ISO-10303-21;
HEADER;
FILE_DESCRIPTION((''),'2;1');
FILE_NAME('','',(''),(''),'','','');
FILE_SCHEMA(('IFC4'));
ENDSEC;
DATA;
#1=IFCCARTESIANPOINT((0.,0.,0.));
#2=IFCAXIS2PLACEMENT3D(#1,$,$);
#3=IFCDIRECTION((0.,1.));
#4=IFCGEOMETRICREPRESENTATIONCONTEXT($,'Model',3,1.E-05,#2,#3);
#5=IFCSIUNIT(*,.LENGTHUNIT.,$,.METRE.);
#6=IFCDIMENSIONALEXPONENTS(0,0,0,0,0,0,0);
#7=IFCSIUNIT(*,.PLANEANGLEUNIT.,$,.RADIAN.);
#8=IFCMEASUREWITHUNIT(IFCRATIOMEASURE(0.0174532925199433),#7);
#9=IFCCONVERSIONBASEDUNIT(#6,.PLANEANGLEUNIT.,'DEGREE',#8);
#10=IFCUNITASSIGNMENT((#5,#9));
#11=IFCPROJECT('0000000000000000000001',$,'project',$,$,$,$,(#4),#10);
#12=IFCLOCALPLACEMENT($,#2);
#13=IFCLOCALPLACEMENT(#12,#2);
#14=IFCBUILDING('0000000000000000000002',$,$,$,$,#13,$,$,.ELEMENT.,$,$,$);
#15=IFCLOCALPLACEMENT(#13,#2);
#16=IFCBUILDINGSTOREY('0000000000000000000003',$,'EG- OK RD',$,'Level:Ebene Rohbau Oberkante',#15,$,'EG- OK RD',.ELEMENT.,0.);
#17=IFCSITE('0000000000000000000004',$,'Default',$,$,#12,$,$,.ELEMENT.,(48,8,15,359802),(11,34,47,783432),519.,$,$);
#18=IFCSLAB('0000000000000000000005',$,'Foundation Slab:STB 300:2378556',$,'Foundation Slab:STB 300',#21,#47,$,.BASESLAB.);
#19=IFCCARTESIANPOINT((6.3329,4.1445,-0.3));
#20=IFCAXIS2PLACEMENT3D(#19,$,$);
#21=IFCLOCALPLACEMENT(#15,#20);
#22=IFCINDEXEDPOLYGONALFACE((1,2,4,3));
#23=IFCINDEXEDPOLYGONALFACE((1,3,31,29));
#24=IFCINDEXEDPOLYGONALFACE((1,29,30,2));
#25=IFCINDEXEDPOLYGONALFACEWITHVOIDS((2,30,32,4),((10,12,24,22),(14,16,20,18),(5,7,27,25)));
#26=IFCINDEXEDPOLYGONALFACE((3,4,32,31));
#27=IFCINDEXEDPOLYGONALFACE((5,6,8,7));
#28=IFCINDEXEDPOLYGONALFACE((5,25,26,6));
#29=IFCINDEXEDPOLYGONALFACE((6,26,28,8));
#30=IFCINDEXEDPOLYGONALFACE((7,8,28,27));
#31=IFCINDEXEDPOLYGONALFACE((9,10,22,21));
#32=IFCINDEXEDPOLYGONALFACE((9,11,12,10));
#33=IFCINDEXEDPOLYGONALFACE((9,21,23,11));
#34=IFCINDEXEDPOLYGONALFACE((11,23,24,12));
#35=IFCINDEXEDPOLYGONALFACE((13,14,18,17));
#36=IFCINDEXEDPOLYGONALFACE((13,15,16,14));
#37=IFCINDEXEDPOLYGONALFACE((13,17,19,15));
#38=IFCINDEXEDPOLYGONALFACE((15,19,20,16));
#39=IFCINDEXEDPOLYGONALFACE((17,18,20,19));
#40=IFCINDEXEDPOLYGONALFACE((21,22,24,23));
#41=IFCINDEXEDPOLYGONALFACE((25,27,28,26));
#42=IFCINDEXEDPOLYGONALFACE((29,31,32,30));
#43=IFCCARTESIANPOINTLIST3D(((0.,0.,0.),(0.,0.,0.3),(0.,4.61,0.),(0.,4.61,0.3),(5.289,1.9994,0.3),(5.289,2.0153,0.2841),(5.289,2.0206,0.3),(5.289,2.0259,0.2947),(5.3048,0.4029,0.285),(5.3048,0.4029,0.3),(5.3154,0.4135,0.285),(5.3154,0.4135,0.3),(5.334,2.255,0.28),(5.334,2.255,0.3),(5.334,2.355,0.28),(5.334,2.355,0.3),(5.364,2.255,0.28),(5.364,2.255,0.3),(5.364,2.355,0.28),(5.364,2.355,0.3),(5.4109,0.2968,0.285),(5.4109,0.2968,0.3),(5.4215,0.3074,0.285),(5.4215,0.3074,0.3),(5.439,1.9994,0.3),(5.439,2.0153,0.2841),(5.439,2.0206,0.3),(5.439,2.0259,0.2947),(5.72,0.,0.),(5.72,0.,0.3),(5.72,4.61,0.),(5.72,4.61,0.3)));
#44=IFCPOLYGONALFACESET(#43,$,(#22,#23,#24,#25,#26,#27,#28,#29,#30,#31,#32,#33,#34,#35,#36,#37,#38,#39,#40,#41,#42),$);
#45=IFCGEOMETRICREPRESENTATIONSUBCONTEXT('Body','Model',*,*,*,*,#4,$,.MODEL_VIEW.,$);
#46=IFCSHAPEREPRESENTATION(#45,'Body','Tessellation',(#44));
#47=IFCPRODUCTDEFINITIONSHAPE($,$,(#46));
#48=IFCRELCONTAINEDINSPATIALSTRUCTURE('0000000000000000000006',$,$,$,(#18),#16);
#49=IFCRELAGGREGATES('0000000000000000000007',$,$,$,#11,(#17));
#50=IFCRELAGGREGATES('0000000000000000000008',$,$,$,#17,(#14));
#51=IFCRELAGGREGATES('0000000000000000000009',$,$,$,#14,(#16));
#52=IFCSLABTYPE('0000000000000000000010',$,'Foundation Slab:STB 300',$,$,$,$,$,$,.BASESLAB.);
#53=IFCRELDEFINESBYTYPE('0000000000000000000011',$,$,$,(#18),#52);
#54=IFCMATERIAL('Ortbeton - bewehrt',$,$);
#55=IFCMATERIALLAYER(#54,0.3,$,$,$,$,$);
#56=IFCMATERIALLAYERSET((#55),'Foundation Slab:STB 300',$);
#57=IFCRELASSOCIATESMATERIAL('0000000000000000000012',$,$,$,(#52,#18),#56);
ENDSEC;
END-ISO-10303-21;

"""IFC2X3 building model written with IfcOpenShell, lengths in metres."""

from ifc_helpers import new_model, entity, si_unit, converted_unit, direction, frame, frame_2d, origin, origin_2d_with_axis, place, context, subcontext, project, spatial, rectangle, extrude, material, layer, layer_set, layer_usage, type_object, element, save


model = new_model("IFC2X3")

# Units and contexts
model_context = context("Model", 3, precision=1e-05, world=origin(), true_north=direction((0.0, 1.0)))
body_context = subcontext(model_context, "Body", "Model", "MODEL_VIEW")
ifc_project = project(units=[si_unit("LENGTHUNIT", "METRE"), converted_unit("PLANEANGLEUNIT", "DEGREE", entity("IfcRatioMeasure", 0.0174532925199433), si_unit("PLANEANGLEUNIT", "RADIAN"), dimensions=[0, 0, 0, 0, 0, 0, 0])], contexts=[model_context])

# Site, building, storey
site_placement = place(None, origin())
site = spatial("IfcSite", under=ifc_project, at=site_placement, Name="Default", CompositionType="ELEMENT", RefLatitude=(48, 8, 15, 359802), RefLongitude=(11, 34, 47, 783432), RefElevation=519.0)
building_placement = place(site_placement, origin())
building = spatial("IfcBuilding", under=site, at=building_placement, CompositionType="ELEMENT")
storey_placement = place(building_placement, origin())
storey = spatial("IfcBuildingStorey", under=building, at=storey_placement, Name="EG- OK RD", ObjectType="Level:Ebene Rohbau Oberkante", LongName="EG- OK RD", CompositionType="ELEMENT", Elevation=0.0)

# Slab, openings
ifc_material_1 = material(Name="Ortbeton - bewehrt")
ifc_layer_1 = layer(ifc_material_1, 0.3)
ifc_layer_set_1 = layer_set([ifc_layer_1], Name="Foundation Slab:STB 300")
ifc_layer_usage_1 = layer_usage(ifc_layer_set_1, "AXIS3", "POSITIVE", 0.0)
slab_type_1 = type_object("IfcSlabType", Name="Foundation Slab:STB 300", PredefinedType="BASESLAB", material=ifc_layer_set_1)
slab_1_placement = place(storey_placement, frame((6.3329, 4.1445, -0.3)))
slab_1 = element("IfcSlab", 1, at=slab_1_placement, inside=storey, type_object=slab_type_1, material=ifc_layer_usage_1, Name="Foundation Slab:STB 300:2378556", ObjectType="Foundation Slab:STB 300", PredefinedType="BASESLAB", context=body_context, shape_type="SweptSolid", body=[
    extrude(rectangle(XDim=4.61, YDim=5.72, at=frame_2d((0.0, 0.0), x_axis=(0.0, -1.0))), frame((2.86, 2.305, 0.3), z_axis=(0.0, 0.0, -1.0), x_axis=(-1.0, 0.0, 0.0)), (0.0, 0.0, 1.0), 0.3),
])
opening_1_placement = place(slab_1_placement, origin())
element("IfcOpeningElement", 2, at=opening_1_placement, cuts=slab_1, ObjectType="Opening", context=body_context, shape_type="SweptSolid", body=[
    extrude(rectangle(XDim=0.03, YDim=0.1, at=origin_2d_with_axis()), frame((5.349, 2.305, 0.28), z_axis=(0.0, 0.0, 1.0), x_axis=(-1.0, 0.0, 0.0)), (0.0, 0.0, 1.0), 0.52),
])
opening_2_placement = place(slab_1_placement, origin())
element("IfcOpeningElement", 3, at=opening_2_placement, cuts=slab_1, ObjectType="Opening", context=body_context, shape_type="SweptSolid", body=[
    extrude(rectangle(XDim=0.0285, YDim=0.015, at=origin_2d_with_axis()), frame((5.289, 2.0105, 0.2995), z_axis=(1.0, 0.0, 0.0), x_axis=(0.0, 0.707107, -0.707107)), (0.0, 0.0, 1.0), 0.15),
])
opening_3_placement = place(slab_1_placement, origin())
element("IfcOpeningElement", 4, at=opening_3_placement, cuts=slab_1, ObjectType="Opening", context=body_context, shape_type="SweptSolid", body=[
    extrude(rectangle(XDim=0.015, YDim=0.15, at=origin_2d_with_axis()), frame((5.3632, 0.3552, 0.285), z_axis=(0.0, 0.0, 1.0), x_axis=(0.707107, 0.707107, 0.0)), (0.0, 0.0, 1.0), 0.0285),
])

save(model, "model.ifc")
